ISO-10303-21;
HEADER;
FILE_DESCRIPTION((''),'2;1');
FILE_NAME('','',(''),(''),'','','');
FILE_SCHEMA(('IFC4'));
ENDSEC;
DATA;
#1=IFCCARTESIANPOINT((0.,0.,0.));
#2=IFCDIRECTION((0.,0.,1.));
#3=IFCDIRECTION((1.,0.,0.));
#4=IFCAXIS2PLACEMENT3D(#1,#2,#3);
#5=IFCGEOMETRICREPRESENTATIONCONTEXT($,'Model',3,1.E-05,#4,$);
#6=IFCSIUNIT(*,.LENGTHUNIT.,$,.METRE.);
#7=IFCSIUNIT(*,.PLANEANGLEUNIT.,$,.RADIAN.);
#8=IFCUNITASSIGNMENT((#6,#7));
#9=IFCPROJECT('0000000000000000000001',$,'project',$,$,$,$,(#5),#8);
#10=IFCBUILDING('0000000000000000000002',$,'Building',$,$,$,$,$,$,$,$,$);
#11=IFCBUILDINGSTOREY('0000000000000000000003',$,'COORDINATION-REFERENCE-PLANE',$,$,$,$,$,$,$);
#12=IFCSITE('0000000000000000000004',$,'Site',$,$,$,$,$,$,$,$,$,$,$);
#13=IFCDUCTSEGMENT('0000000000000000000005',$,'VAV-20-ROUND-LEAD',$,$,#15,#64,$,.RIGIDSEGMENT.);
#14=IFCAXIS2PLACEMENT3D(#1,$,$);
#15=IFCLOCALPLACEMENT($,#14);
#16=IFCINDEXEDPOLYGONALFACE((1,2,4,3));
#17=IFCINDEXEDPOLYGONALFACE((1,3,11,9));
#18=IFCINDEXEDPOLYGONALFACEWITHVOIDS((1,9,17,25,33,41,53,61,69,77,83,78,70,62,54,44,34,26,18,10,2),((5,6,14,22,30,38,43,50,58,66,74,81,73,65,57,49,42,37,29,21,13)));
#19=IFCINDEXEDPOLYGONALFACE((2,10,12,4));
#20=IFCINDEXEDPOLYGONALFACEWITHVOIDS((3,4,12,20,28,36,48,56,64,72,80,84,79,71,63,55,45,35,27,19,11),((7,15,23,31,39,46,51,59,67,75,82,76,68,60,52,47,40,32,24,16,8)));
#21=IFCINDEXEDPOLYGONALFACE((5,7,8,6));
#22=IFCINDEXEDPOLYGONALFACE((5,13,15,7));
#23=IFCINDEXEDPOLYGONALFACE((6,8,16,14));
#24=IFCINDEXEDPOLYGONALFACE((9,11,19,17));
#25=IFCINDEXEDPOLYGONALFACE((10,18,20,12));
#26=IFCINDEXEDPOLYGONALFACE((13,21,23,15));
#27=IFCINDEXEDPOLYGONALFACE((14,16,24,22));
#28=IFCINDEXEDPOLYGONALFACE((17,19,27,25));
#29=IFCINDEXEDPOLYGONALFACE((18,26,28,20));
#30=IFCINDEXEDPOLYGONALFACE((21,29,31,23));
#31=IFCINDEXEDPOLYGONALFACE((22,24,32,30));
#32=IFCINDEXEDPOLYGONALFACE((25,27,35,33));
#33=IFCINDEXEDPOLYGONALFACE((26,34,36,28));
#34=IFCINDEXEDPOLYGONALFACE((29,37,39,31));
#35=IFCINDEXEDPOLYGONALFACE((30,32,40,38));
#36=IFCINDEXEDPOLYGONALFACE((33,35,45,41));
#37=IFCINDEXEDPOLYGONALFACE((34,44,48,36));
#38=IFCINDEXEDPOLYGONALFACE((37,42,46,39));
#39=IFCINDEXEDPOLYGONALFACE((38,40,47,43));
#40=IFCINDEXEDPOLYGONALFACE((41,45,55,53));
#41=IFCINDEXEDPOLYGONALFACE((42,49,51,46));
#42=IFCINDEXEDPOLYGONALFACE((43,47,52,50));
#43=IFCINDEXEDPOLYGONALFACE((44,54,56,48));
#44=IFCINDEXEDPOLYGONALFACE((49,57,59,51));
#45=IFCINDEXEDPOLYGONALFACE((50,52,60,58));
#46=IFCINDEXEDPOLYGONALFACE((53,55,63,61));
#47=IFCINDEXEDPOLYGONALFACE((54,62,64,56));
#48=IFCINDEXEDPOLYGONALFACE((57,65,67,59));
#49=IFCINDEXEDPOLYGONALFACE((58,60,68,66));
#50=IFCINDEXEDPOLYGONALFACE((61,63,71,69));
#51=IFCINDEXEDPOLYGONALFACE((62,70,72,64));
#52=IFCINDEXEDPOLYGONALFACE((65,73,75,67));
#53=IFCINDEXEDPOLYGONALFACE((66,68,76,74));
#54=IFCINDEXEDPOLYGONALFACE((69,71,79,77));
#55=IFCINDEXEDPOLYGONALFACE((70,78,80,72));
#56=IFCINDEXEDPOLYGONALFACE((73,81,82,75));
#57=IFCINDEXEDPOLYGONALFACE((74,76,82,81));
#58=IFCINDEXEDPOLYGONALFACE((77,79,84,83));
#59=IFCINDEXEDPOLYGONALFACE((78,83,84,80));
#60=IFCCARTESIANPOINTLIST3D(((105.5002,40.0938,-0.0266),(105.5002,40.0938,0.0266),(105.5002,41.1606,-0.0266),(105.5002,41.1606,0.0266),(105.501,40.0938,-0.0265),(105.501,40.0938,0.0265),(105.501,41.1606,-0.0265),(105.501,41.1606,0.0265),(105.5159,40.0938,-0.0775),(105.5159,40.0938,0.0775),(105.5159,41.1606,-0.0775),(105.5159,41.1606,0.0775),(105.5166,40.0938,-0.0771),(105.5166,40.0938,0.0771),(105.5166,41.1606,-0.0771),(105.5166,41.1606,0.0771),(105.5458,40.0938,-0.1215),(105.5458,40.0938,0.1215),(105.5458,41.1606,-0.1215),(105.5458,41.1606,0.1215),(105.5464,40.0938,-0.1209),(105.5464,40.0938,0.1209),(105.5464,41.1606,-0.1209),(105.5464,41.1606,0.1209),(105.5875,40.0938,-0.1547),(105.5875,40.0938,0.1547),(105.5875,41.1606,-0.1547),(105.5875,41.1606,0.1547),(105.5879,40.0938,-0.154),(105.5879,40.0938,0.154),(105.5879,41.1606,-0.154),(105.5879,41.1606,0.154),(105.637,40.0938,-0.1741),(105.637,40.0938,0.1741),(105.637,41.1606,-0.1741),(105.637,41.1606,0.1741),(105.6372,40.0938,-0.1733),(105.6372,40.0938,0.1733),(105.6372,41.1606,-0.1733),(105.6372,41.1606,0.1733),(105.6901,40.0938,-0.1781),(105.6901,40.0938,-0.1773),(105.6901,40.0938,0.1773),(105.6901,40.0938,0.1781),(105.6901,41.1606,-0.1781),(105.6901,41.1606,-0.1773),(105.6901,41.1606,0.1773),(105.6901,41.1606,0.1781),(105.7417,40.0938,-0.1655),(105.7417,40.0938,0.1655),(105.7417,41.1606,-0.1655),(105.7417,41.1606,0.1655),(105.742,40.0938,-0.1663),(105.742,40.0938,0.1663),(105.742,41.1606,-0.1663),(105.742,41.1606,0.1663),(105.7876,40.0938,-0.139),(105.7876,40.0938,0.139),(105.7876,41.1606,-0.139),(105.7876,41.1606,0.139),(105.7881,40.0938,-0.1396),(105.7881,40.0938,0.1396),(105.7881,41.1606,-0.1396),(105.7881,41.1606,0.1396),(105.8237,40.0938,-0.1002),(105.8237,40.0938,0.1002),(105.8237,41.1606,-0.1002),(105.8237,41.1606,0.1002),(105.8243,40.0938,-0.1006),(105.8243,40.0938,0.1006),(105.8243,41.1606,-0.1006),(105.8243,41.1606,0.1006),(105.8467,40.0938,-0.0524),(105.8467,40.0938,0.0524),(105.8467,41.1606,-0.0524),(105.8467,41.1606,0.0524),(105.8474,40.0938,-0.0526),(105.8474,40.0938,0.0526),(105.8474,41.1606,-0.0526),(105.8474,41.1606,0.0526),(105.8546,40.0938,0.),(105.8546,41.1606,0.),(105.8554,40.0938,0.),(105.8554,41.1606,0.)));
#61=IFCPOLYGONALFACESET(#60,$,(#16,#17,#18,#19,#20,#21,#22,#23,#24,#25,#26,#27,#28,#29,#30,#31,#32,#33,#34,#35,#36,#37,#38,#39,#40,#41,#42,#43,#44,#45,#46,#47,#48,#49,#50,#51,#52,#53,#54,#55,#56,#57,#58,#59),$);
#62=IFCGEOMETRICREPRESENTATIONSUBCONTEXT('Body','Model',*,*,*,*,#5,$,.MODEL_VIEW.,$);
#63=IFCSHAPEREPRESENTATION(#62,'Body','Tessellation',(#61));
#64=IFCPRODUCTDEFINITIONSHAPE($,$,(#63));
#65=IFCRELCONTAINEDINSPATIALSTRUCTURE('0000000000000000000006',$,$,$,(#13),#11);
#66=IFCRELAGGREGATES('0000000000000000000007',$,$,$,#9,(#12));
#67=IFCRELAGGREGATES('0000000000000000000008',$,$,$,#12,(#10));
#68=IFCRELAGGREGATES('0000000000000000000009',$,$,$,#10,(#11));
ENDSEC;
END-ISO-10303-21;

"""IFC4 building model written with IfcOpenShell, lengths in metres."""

from ifc_helpers import new_model, si_unit, frame, origin, origin_with_axes, place, context, subcontext, project, spatial, hollow_circle, extrude, element, save


model = new_model("IFC4")

# Units and contexts
model_context_1 = context("Model", 3, precision=1e-05, world=origin_with_axes())
body_context_1 = subcontext(model_context_1, "Body", "Model", "MODEL_VIEW")
ifc_project = project(units=[si_unit("LENGTHUNIT", "METRE"), si_unit("PLANEANGLEUNIT", "RADIAN")], contexts=[model_context_1])

# Site, building, storey
site = spatial("IfcSite", under=ifc_project, Name="Site")
building = spatial("IfcBuilding", under=site, Name="Building")
storey = spatial("IfcBuildingStorey", under=building, Name="COORDINATION-REFERENCE-PLANE")

# Duct segment
duct_segment_1_placement = place(None, frame((105.6768, 40.0938, 0.0), z_axis=(0.0, 1.0, 0.0), x_axis=(1.0, 0.0, 0.0)))
element("IfcDuctSegment", 1, at=duct_segment_1_placement, inside=storey, Name="VAV-20-ROUND-LEAD", PredefinedType="RIGIDSEGMENT", context=body_context_1, shape_type="SweptSolid", body=[
    extrude(hollow_circle(Radius=0.1786, WallThickness=0.0008), origin(), (0.0, 0.0, 1.0), 1.0668),
])

save(model, "model.ifc")
